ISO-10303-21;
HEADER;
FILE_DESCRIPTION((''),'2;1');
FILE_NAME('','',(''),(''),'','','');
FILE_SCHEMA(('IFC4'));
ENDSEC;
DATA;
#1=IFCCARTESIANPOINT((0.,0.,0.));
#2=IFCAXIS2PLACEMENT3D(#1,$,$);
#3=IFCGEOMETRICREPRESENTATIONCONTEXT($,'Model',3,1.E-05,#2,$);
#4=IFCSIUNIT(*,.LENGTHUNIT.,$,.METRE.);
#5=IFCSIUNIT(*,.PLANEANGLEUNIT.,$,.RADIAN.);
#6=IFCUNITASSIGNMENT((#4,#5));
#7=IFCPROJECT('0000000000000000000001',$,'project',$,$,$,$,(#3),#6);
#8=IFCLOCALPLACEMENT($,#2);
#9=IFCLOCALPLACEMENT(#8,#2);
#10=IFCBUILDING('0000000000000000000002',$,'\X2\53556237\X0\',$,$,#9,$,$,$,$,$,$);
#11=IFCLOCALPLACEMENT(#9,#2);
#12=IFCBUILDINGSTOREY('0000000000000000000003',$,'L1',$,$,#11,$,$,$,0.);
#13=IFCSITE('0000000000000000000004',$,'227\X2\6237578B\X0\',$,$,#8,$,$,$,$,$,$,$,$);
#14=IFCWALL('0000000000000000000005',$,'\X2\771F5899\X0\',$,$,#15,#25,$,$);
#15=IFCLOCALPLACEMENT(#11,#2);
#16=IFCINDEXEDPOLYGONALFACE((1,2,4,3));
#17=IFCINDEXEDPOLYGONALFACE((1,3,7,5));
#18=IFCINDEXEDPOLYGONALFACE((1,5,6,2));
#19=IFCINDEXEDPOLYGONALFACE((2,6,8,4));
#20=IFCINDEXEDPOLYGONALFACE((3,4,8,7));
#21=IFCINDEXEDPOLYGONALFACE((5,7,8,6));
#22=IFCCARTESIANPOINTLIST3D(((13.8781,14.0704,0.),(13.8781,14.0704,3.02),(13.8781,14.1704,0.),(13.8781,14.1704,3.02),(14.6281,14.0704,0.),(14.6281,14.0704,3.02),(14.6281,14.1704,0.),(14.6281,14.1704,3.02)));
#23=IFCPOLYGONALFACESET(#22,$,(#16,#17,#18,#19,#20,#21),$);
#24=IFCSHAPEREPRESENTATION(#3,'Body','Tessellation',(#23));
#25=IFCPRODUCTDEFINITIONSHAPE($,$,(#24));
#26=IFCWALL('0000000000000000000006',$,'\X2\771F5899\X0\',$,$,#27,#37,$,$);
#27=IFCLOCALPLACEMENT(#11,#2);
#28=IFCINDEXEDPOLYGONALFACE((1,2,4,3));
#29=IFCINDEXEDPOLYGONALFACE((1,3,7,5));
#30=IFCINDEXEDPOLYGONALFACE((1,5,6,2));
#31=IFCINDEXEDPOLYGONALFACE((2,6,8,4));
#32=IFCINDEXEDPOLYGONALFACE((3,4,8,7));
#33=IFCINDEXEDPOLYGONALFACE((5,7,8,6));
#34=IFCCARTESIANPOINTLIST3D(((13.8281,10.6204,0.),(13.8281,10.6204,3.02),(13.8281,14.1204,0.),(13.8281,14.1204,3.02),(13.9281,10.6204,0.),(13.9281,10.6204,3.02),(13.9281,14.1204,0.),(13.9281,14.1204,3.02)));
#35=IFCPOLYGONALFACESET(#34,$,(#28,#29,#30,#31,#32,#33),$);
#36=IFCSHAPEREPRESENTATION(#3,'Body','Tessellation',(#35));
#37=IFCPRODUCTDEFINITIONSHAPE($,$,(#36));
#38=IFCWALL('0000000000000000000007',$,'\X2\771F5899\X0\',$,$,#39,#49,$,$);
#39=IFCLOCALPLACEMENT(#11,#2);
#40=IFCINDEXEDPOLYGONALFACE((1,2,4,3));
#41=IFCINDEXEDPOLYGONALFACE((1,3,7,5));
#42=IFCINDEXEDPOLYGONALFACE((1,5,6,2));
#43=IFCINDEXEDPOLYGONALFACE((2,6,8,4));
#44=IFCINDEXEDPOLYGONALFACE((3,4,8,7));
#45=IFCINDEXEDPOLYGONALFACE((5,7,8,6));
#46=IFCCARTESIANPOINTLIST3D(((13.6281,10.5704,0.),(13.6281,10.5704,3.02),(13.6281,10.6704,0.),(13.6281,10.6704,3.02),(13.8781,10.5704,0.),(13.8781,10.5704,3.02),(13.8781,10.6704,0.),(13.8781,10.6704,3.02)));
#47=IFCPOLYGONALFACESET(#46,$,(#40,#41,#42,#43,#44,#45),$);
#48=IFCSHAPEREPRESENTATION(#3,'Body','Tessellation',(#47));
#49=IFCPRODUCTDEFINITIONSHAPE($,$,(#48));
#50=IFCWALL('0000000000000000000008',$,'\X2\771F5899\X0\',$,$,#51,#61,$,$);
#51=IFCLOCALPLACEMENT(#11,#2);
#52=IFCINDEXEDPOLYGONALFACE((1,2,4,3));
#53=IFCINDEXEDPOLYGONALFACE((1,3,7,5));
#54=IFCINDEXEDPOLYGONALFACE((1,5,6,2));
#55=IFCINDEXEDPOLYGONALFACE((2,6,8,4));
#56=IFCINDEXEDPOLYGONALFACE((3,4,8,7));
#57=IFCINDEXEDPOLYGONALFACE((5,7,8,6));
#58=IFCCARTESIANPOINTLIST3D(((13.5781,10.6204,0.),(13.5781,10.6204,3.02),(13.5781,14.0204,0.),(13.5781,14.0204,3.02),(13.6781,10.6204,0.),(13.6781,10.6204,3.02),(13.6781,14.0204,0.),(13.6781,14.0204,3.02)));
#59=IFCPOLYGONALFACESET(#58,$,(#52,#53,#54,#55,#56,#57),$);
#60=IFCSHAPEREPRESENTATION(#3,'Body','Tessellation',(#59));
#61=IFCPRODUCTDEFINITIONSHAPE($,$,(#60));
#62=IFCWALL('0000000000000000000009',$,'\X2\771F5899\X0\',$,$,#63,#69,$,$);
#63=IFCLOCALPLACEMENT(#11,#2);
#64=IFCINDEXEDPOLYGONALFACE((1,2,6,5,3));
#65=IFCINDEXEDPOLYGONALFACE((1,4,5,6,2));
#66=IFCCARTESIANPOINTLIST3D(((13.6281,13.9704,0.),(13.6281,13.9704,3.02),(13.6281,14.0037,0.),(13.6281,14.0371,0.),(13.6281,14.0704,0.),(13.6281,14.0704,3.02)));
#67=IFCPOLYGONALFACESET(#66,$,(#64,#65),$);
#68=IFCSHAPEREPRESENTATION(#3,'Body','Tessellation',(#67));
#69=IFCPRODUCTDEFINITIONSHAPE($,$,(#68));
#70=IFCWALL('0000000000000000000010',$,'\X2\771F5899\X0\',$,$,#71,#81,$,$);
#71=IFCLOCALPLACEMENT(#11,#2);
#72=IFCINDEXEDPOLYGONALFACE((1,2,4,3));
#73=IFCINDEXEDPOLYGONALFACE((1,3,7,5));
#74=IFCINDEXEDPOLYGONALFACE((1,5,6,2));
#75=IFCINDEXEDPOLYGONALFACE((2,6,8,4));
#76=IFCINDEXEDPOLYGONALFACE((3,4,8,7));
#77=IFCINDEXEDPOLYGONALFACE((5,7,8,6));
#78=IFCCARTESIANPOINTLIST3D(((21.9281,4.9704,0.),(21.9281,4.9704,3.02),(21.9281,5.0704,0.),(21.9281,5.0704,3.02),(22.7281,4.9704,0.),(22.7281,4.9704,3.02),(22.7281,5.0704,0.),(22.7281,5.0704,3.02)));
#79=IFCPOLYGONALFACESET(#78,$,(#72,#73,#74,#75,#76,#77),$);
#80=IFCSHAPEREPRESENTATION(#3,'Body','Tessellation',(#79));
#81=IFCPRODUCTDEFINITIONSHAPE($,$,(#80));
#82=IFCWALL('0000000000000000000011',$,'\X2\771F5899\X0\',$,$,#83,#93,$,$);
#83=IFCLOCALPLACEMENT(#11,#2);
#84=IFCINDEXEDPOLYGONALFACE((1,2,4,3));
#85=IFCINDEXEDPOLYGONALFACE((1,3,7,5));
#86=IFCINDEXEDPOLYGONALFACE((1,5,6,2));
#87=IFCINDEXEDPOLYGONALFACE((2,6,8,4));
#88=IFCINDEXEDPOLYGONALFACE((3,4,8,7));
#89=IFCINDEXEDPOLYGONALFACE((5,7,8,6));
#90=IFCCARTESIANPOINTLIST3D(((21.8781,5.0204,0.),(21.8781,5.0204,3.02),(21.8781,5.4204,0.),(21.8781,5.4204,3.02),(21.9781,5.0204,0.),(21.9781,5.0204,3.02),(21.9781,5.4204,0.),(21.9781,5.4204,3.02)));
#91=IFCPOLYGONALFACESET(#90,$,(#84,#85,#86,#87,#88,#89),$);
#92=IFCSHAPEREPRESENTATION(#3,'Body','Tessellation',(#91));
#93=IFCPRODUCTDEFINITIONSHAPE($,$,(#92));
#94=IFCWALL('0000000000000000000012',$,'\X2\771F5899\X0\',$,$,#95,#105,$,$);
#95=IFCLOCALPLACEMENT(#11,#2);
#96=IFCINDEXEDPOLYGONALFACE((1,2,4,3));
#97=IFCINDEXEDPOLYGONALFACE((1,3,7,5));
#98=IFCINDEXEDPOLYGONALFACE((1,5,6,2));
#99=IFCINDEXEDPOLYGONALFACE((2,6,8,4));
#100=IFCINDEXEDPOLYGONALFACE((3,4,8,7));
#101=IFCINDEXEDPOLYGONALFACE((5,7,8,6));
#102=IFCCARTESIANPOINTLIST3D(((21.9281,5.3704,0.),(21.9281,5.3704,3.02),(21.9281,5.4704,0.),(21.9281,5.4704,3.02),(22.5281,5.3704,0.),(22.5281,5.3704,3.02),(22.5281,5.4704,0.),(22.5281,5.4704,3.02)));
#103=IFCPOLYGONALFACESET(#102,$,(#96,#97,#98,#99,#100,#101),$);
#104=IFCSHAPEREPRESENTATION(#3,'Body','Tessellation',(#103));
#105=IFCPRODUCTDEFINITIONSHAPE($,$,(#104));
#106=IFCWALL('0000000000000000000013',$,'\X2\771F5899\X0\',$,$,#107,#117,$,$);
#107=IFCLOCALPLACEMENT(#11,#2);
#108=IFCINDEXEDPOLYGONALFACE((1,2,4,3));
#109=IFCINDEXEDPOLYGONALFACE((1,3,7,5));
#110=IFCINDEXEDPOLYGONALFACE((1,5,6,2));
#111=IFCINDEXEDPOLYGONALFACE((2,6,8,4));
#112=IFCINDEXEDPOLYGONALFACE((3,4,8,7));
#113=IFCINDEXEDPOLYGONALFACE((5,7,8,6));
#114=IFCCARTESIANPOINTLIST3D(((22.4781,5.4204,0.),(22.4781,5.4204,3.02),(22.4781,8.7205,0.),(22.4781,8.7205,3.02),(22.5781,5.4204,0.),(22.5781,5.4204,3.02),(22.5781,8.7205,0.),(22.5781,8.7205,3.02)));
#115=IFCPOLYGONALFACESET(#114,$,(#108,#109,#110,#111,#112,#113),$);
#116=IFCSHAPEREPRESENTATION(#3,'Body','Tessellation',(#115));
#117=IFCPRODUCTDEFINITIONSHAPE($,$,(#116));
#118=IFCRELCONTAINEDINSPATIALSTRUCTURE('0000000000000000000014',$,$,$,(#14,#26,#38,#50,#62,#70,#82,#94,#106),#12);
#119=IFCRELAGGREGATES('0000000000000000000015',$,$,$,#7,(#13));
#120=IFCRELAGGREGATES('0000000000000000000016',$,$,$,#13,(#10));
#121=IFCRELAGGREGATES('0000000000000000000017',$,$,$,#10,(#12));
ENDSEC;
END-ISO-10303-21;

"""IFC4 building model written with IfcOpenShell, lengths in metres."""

from ifc_helpers import new_model, si_unit, origin, place, context, project, spatial, polyline, outline, extrude, element, save


model = new_model("IFC4")

# Units and contexts
model_context = context("Model", 3, precision=1e-05, world=origin())
ifc_project = project(units=[si_unit("LENGTHUNIT", "METRE"), si_unit("PLANEANGLEUNIT", "RADIAN")], contexts=[model_context])

# Site, building, storey
site_placement = place(None, origin())
site = spatial("IfcSite", under=ifc_project, at=site_placement, Name="227户型")
building_placement = place(site_placement, origin())
building = spatial("IfcBuilding", under=site, at=building_placement, Name="单户")
storey_placement = place(building_placement, origin())
storey = spatial("IfcBuildingStorey", under=building, at=storey_placement, Name="L1", Elevation=0.0)

# Walls
wall_1_placement = place(storey_placement, origin())
element("IfcWall", 1, at=wall_1_placement, inside=storey, Name="真墙", context=model_context, shape_type="SweptSolid", body=[
    extrude(outline(polyline([(14.6281, 14.0704), (13.8781, 14.0704), (13.8781, 14.1704), (14.6281, 14.1704), (14.6281, 14.0704)])), origin(), (0.0, 0.0, 1.0), 3.02),
])
wall_2_placement = place(storey_placement, origin())
element("IfcWall", 2, at=wall_2_placement, inside=storey, Name="真墙", context=model_context, shape_type="SweptSolid", body=[
    extrude(outline(polyline([(13.9281, 14.1204), (13.9281, 10.6204), (13.8281, 10.6204), (13.8281, 14.1204), (13.9281, 14.1204)])), origin(), (0.0, 0.0, 1.0), 3.02),
])
wall_3_placement = place(storey_placement, origin())
element("IfcWall", 3, at=wall_3_placement, inside=storey, Name="真墙", context=model_context, shape_type="SweptSolid", body=[
    extrude(outline(polyline([(13.8781, 10.5704), (13.6281, 10.5704), (13.6281, 10.6704), (13.8781, 10.6704), (13.8781, 10.5704)])), origin(), (0.0, 0.0, 1.0), 3.02),
])
wall_4_placement = place(storey_placement, origin())
element("IfcWall", 4, at=wall_4_placement, inside=storey, Name="真墙", context=model_context, shape_type="SweptSolid", body=[
    extrude(outline(polyline([(13.5781, 10.6204), (13.5781, 14.0204), (13.6781, 14.0204), (13.6781, 10.6204), (13.5781, 10.6204)])), origin(), (0.0, 0.0, 1.0), 3.02),
])
wall_5_placement = place(storey_placement, origin())
element("IfcWall", 5, at=wall_5_placement, inside=storey, Name="真墙", context=model_context, shape_type="SweptSolid", body=[
    extrude(outline(polyline([(13.6281, 13.9704), (13.6281, 13.9704), (13.6281, 14.0704), (13.6281, 14.0704), (13.6281, 13.9704)])), origin(), (0.0, 0.0, 1.0), 3.02),
])
wall_6_placement = place(storey_placement, origin())
element("IfcWall", 6, at=wall_6_placement, inside=storey, Name="真墙", context=model_context, shape_type="SweptSolid", body=[
    extrude(outline(polyline([(22.7281, 4.9704), (21.9281, 4.9704), (21.9281, 5.0704), (22.7281, 5.0704), (22.7281, 4.9704)])), origin(), (0.0, 0.0, 1.0), 3.02),
])
wall_7_placement = place(storey_placement, origin())
element("IfcWall", 7, at=wall_7_placement, inside=storey, Name="真墙", context=model_context, shape_type="SweptSolid", body=[
    extrude(outline(polyline([(21.8781, 5.0204), (21.8781, 5.4204), (21.9781, 5.4204), (21.9781, 5.0204), (21.8781, 5.0204)])), origin(), (0.0, 0.0, 1.0), 3.02),
])
wall_8_placement = place(storey_placement, origin())
element("IfcWall", 8, at=wall_8_placement, inside=storey, Name="真墙", context=model_context, shape_type="SweptSolid", body=[
    extrude(outline(polyline([(21.9281, 5.4704), (22.5281, 5.4704), (22.5281, 5.3704), (21.9281, 5.3704), (21.9281, 5.4704)])), origin(), (0.0, 0.0, 1.0), 3.02),
])
wall_9_placement = place(storey_placement, origin())
element("IfcWall", 9, at=wall_9_placement, inside=storey, Name="真墙", context=model_context, shape_type="SweptSolid", body=[
    extrude(outline(polyline([(22.4781, 5.4204), (22.4781, 8.7205), (22.5781, 8.7205), (22.5781, 5.4204), (22.4781, 5.4204)])), origin(), (0.0, 0.0, 1.0), 3.02),
])

save(model, "model.ifc")
